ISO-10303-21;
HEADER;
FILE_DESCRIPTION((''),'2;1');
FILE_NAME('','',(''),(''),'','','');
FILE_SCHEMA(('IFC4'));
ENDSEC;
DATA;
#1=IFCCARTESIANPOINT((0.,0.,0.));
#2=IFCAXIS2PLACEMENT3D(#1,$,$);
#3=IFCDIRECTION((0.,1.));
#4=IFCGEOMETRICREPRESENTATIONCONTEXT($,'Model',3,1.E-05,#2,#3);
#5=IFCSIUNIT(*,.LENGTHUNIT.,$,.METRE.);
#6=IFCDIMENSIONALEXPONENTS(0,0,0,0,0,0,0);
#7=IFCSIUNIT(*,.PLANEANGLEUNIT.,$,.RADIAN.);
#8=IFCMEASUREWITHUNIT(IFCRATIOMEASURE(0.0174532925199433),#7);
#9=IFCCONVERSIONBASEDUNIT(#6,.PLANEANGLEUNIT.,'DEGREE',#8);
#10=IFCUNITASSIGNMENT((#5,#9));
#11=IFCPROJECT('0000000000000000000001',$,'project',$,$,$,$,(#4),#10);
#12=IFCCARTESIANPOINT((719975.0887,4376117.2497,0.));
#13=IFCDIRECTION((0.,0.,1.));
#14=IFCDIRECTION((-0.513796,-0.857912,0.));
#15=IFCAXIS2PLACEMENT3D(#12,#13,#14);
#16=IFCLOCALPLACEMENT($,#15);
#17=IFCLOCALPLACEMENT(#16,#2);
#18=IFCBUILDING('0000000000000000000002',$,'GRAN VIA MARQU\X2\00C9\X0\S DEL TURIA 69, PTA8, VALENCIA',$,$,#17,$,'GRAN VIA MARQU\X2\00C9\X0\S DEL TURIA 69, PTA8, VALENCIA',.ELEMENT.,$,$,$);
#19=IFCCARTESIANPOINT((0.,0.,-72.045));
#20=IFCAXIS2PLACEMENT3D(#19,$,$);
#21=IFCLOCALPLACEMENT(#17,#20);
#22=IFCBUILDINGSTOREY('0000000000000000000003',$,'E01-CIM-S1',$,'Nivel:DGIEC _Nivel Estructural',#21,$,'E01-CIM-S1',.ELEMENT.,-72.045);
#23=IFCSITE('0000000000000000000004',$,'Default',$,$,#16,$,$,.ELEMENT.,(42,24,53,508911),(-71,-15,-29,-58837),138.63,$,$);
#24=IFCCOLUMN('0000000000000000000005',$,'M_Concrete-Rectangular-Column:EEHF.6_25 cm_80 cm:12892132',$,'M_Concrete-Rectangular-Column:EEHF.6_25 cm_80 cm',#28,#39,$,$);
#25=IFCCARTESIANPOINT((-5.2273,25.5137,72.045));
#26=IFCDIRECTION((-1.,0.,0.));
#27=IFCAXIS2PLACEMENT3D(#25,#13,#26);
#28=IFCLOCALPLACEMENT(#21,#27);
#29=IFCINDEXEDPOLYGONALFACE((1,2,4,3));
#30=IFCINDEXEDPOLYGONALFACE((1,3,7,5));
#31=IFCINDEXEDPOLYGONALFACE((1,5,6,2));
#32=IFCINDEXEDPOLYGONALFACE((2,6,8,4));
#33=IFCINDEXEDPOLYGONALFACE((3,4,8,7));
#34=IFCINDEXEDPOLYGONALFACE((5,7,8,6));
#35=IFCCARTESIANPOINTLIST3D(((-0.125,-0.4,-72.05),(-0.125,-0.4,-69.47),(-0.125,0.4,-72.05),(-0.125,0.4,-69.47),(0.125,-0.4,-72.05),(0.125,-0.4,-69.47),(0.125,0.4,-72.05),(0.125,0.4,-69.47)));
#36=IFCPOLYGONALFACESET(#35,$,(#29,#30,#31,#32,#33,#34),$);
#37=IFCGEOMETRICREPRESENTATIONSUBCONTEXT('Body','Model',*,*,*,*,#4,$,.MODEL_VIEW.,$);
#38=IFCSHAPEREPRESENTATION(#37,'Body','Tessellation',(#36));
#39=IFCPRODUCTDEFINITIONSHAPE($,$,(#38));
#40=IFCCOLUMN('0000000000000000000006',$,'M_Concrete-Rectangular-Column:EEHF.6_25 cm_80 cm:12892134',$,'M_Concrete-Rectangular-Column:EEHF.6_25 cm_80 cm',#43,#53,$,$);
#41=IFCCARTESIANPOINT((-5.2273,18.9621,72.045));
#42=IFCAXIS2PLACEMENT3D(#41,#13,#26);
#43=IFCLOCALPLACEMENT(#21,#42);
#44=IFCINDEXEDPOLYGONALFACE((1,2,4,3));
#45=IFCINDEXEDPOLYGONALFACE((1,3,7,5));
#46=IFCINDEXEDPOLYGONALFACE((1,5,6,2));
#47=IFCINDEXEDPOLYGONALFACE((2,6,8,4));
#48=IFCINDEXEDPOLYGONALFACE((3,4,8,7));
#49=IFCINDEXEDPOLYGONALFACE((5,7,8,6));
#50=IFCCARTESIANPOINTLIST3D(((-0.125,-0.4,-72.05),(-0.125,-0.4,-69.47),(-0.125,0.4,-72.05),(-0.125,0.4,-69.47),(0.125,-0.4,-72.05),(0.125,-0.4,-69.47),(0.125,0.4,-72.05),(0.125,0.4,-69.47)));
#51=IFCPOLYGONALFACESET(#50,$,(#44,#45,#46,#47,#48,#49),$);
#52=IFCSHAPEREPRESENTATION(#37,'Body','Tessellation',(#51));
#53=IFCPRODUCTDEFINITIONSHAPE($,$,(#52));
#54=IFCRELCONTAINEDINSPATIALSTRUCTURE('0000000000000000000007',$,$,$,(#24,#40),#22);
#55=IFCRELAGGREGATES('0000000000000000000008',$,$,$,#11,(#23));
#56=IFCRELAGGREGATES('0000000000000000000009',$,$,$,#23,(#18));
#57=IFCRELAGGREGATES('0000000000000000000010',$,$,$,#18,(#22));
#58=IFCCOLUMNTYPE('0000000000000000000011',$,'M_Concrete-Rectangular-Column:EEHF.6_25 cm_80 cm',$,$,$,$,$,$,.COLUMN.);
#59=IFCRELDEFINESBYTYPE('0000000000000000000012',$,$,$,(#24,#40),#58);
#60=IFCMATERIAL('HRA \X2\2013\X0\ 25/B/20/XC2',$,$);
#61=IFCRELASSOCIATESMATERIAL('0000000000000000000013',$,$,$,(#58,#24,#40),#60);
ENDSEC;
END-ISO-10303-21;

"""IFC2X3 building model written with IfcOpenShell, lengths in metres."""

from ifc_helpers import new_model, entity, si_unit, converted_unit, direction, frame, origin, origin_2d_with_axis, place, context, subcontext, project, spatial, rectangle, extrude, source, transform, mapped, material, type_object, type_shapes, element, save


model = new_model("IFC2X3")

# Units and contexts
model_context = context("Model", 3, precision=1e-05, world=origin(), true_north=direction((0.0, 1.0)))
body_context = subcontext(model_context, "Body", "Model", "MODEL_VIEW")
ifc_project = project(units=[si_unit("LENGTHUNIT", "METRE"), converted_unit("PLANEANGLEUNIT", "DEGREE", entity("IfcRatioMeasure", 0.0174532925199433), si_unit("PLANEANGLEUNIT", "RADIAN"), dimensions=[0, 0, 0, 0, 0, 0, 0])], contexts=[model_context])

# Site, building, storey
site_placement = place(None, frame((719975.0887, 4376117.2497, 0.0), z_axis=(0.0, 0.0, 1.0), x_axis=(-0.513796, -0.857912, 0.0)))
site = spatial("IfcSite", under=ifc_project, at=site_placement, Name="Default", CompositionType="ELEMENT", RefLatitude=(42, 24, 53, 508911), RefLongitude=(-71, -15, -29, -58837), RefElevation=138.63)
building_placement = place(site_placement, origin())
building = spatial("IfcBuilding", under=site, at=building_placement, Name="GRAN VIA MARQUÉS DEL TURIA 69, PTA8, VALENCIA", LongName="GRAN VIA MARQUÉS DEL TURIA 69, PTA8, VALENCIA", CompositionType="ELEMENT")
storey_placement = place(building_placement, frame((0.0, 0.0, -72.045)))
storey = spatial("IfcBuildingStorey", under=building, at=storey_placement, Name="E01-CIM-S1", ObjectType="Nivel:DGIEC _Nivel Estructural", LongName="E01-CIM-S1", CompositionType="ELEMENT", Elevation=-72.045)

# Columns
ifc_material = material(Name="HRA – 25/B/20/XC2")
column_type = type_object("IfcColumnType", Name="M_Concrete-Rectangular-Column:EEHF.6_25 cm_80 cm", PredefinedType="COLUMN", material=ifc_material)
shared_shape = source(origin(), body_context, "Body", "SweptSolid", [
    extrude(rectangle(XDim=0.8, YDim=0.25, at=origin_2d_with_axis()), frame((0.0, 0.0, -72.05), z_axis=(0.0, 0.0, 1.0), x_axis=(0.0, -1.0, 0.0)), (0.0, 0.0, 1.0), 2.58),
])
type_shapes(column_type, [shared_shape])
for number, where, z_axis, x_axis, name in (
    (1, (-5.2273, 25.5137, 72.045), (0.0, 0.0, 1.0), (-1.0, 0.0, 0.0), "M_Concrete-Rectangular-Column:EEHF.6_25 cm_80 cm:12892132"),
    (2, (-5.2273, 18.9621, 72.045), (0.0, 0.0, 1.0), (-1.0, 0.0, 0.0), "M_Concrete-Rectangular-Column:EEHF.6_25 cm_80 cm:12892134"),
):
    element("IfcColumn", number, at=place(storey_placement, frame(where, z_axis=z_axis, x_axis=x_axis)), inside=storey, type_object=column_type, material=ifc_material, Name=name, ObjectType="M_Concrete-Rectangular-Column:EEHF.6_25 cm_80 cm", context=body_context, shape_type="MappedRepresentation", body=[
        mapped(shared_shape, transform((0.0, 0.0, 0.0), scale=1.0)),
    ])

save(model, "model.ifc")
